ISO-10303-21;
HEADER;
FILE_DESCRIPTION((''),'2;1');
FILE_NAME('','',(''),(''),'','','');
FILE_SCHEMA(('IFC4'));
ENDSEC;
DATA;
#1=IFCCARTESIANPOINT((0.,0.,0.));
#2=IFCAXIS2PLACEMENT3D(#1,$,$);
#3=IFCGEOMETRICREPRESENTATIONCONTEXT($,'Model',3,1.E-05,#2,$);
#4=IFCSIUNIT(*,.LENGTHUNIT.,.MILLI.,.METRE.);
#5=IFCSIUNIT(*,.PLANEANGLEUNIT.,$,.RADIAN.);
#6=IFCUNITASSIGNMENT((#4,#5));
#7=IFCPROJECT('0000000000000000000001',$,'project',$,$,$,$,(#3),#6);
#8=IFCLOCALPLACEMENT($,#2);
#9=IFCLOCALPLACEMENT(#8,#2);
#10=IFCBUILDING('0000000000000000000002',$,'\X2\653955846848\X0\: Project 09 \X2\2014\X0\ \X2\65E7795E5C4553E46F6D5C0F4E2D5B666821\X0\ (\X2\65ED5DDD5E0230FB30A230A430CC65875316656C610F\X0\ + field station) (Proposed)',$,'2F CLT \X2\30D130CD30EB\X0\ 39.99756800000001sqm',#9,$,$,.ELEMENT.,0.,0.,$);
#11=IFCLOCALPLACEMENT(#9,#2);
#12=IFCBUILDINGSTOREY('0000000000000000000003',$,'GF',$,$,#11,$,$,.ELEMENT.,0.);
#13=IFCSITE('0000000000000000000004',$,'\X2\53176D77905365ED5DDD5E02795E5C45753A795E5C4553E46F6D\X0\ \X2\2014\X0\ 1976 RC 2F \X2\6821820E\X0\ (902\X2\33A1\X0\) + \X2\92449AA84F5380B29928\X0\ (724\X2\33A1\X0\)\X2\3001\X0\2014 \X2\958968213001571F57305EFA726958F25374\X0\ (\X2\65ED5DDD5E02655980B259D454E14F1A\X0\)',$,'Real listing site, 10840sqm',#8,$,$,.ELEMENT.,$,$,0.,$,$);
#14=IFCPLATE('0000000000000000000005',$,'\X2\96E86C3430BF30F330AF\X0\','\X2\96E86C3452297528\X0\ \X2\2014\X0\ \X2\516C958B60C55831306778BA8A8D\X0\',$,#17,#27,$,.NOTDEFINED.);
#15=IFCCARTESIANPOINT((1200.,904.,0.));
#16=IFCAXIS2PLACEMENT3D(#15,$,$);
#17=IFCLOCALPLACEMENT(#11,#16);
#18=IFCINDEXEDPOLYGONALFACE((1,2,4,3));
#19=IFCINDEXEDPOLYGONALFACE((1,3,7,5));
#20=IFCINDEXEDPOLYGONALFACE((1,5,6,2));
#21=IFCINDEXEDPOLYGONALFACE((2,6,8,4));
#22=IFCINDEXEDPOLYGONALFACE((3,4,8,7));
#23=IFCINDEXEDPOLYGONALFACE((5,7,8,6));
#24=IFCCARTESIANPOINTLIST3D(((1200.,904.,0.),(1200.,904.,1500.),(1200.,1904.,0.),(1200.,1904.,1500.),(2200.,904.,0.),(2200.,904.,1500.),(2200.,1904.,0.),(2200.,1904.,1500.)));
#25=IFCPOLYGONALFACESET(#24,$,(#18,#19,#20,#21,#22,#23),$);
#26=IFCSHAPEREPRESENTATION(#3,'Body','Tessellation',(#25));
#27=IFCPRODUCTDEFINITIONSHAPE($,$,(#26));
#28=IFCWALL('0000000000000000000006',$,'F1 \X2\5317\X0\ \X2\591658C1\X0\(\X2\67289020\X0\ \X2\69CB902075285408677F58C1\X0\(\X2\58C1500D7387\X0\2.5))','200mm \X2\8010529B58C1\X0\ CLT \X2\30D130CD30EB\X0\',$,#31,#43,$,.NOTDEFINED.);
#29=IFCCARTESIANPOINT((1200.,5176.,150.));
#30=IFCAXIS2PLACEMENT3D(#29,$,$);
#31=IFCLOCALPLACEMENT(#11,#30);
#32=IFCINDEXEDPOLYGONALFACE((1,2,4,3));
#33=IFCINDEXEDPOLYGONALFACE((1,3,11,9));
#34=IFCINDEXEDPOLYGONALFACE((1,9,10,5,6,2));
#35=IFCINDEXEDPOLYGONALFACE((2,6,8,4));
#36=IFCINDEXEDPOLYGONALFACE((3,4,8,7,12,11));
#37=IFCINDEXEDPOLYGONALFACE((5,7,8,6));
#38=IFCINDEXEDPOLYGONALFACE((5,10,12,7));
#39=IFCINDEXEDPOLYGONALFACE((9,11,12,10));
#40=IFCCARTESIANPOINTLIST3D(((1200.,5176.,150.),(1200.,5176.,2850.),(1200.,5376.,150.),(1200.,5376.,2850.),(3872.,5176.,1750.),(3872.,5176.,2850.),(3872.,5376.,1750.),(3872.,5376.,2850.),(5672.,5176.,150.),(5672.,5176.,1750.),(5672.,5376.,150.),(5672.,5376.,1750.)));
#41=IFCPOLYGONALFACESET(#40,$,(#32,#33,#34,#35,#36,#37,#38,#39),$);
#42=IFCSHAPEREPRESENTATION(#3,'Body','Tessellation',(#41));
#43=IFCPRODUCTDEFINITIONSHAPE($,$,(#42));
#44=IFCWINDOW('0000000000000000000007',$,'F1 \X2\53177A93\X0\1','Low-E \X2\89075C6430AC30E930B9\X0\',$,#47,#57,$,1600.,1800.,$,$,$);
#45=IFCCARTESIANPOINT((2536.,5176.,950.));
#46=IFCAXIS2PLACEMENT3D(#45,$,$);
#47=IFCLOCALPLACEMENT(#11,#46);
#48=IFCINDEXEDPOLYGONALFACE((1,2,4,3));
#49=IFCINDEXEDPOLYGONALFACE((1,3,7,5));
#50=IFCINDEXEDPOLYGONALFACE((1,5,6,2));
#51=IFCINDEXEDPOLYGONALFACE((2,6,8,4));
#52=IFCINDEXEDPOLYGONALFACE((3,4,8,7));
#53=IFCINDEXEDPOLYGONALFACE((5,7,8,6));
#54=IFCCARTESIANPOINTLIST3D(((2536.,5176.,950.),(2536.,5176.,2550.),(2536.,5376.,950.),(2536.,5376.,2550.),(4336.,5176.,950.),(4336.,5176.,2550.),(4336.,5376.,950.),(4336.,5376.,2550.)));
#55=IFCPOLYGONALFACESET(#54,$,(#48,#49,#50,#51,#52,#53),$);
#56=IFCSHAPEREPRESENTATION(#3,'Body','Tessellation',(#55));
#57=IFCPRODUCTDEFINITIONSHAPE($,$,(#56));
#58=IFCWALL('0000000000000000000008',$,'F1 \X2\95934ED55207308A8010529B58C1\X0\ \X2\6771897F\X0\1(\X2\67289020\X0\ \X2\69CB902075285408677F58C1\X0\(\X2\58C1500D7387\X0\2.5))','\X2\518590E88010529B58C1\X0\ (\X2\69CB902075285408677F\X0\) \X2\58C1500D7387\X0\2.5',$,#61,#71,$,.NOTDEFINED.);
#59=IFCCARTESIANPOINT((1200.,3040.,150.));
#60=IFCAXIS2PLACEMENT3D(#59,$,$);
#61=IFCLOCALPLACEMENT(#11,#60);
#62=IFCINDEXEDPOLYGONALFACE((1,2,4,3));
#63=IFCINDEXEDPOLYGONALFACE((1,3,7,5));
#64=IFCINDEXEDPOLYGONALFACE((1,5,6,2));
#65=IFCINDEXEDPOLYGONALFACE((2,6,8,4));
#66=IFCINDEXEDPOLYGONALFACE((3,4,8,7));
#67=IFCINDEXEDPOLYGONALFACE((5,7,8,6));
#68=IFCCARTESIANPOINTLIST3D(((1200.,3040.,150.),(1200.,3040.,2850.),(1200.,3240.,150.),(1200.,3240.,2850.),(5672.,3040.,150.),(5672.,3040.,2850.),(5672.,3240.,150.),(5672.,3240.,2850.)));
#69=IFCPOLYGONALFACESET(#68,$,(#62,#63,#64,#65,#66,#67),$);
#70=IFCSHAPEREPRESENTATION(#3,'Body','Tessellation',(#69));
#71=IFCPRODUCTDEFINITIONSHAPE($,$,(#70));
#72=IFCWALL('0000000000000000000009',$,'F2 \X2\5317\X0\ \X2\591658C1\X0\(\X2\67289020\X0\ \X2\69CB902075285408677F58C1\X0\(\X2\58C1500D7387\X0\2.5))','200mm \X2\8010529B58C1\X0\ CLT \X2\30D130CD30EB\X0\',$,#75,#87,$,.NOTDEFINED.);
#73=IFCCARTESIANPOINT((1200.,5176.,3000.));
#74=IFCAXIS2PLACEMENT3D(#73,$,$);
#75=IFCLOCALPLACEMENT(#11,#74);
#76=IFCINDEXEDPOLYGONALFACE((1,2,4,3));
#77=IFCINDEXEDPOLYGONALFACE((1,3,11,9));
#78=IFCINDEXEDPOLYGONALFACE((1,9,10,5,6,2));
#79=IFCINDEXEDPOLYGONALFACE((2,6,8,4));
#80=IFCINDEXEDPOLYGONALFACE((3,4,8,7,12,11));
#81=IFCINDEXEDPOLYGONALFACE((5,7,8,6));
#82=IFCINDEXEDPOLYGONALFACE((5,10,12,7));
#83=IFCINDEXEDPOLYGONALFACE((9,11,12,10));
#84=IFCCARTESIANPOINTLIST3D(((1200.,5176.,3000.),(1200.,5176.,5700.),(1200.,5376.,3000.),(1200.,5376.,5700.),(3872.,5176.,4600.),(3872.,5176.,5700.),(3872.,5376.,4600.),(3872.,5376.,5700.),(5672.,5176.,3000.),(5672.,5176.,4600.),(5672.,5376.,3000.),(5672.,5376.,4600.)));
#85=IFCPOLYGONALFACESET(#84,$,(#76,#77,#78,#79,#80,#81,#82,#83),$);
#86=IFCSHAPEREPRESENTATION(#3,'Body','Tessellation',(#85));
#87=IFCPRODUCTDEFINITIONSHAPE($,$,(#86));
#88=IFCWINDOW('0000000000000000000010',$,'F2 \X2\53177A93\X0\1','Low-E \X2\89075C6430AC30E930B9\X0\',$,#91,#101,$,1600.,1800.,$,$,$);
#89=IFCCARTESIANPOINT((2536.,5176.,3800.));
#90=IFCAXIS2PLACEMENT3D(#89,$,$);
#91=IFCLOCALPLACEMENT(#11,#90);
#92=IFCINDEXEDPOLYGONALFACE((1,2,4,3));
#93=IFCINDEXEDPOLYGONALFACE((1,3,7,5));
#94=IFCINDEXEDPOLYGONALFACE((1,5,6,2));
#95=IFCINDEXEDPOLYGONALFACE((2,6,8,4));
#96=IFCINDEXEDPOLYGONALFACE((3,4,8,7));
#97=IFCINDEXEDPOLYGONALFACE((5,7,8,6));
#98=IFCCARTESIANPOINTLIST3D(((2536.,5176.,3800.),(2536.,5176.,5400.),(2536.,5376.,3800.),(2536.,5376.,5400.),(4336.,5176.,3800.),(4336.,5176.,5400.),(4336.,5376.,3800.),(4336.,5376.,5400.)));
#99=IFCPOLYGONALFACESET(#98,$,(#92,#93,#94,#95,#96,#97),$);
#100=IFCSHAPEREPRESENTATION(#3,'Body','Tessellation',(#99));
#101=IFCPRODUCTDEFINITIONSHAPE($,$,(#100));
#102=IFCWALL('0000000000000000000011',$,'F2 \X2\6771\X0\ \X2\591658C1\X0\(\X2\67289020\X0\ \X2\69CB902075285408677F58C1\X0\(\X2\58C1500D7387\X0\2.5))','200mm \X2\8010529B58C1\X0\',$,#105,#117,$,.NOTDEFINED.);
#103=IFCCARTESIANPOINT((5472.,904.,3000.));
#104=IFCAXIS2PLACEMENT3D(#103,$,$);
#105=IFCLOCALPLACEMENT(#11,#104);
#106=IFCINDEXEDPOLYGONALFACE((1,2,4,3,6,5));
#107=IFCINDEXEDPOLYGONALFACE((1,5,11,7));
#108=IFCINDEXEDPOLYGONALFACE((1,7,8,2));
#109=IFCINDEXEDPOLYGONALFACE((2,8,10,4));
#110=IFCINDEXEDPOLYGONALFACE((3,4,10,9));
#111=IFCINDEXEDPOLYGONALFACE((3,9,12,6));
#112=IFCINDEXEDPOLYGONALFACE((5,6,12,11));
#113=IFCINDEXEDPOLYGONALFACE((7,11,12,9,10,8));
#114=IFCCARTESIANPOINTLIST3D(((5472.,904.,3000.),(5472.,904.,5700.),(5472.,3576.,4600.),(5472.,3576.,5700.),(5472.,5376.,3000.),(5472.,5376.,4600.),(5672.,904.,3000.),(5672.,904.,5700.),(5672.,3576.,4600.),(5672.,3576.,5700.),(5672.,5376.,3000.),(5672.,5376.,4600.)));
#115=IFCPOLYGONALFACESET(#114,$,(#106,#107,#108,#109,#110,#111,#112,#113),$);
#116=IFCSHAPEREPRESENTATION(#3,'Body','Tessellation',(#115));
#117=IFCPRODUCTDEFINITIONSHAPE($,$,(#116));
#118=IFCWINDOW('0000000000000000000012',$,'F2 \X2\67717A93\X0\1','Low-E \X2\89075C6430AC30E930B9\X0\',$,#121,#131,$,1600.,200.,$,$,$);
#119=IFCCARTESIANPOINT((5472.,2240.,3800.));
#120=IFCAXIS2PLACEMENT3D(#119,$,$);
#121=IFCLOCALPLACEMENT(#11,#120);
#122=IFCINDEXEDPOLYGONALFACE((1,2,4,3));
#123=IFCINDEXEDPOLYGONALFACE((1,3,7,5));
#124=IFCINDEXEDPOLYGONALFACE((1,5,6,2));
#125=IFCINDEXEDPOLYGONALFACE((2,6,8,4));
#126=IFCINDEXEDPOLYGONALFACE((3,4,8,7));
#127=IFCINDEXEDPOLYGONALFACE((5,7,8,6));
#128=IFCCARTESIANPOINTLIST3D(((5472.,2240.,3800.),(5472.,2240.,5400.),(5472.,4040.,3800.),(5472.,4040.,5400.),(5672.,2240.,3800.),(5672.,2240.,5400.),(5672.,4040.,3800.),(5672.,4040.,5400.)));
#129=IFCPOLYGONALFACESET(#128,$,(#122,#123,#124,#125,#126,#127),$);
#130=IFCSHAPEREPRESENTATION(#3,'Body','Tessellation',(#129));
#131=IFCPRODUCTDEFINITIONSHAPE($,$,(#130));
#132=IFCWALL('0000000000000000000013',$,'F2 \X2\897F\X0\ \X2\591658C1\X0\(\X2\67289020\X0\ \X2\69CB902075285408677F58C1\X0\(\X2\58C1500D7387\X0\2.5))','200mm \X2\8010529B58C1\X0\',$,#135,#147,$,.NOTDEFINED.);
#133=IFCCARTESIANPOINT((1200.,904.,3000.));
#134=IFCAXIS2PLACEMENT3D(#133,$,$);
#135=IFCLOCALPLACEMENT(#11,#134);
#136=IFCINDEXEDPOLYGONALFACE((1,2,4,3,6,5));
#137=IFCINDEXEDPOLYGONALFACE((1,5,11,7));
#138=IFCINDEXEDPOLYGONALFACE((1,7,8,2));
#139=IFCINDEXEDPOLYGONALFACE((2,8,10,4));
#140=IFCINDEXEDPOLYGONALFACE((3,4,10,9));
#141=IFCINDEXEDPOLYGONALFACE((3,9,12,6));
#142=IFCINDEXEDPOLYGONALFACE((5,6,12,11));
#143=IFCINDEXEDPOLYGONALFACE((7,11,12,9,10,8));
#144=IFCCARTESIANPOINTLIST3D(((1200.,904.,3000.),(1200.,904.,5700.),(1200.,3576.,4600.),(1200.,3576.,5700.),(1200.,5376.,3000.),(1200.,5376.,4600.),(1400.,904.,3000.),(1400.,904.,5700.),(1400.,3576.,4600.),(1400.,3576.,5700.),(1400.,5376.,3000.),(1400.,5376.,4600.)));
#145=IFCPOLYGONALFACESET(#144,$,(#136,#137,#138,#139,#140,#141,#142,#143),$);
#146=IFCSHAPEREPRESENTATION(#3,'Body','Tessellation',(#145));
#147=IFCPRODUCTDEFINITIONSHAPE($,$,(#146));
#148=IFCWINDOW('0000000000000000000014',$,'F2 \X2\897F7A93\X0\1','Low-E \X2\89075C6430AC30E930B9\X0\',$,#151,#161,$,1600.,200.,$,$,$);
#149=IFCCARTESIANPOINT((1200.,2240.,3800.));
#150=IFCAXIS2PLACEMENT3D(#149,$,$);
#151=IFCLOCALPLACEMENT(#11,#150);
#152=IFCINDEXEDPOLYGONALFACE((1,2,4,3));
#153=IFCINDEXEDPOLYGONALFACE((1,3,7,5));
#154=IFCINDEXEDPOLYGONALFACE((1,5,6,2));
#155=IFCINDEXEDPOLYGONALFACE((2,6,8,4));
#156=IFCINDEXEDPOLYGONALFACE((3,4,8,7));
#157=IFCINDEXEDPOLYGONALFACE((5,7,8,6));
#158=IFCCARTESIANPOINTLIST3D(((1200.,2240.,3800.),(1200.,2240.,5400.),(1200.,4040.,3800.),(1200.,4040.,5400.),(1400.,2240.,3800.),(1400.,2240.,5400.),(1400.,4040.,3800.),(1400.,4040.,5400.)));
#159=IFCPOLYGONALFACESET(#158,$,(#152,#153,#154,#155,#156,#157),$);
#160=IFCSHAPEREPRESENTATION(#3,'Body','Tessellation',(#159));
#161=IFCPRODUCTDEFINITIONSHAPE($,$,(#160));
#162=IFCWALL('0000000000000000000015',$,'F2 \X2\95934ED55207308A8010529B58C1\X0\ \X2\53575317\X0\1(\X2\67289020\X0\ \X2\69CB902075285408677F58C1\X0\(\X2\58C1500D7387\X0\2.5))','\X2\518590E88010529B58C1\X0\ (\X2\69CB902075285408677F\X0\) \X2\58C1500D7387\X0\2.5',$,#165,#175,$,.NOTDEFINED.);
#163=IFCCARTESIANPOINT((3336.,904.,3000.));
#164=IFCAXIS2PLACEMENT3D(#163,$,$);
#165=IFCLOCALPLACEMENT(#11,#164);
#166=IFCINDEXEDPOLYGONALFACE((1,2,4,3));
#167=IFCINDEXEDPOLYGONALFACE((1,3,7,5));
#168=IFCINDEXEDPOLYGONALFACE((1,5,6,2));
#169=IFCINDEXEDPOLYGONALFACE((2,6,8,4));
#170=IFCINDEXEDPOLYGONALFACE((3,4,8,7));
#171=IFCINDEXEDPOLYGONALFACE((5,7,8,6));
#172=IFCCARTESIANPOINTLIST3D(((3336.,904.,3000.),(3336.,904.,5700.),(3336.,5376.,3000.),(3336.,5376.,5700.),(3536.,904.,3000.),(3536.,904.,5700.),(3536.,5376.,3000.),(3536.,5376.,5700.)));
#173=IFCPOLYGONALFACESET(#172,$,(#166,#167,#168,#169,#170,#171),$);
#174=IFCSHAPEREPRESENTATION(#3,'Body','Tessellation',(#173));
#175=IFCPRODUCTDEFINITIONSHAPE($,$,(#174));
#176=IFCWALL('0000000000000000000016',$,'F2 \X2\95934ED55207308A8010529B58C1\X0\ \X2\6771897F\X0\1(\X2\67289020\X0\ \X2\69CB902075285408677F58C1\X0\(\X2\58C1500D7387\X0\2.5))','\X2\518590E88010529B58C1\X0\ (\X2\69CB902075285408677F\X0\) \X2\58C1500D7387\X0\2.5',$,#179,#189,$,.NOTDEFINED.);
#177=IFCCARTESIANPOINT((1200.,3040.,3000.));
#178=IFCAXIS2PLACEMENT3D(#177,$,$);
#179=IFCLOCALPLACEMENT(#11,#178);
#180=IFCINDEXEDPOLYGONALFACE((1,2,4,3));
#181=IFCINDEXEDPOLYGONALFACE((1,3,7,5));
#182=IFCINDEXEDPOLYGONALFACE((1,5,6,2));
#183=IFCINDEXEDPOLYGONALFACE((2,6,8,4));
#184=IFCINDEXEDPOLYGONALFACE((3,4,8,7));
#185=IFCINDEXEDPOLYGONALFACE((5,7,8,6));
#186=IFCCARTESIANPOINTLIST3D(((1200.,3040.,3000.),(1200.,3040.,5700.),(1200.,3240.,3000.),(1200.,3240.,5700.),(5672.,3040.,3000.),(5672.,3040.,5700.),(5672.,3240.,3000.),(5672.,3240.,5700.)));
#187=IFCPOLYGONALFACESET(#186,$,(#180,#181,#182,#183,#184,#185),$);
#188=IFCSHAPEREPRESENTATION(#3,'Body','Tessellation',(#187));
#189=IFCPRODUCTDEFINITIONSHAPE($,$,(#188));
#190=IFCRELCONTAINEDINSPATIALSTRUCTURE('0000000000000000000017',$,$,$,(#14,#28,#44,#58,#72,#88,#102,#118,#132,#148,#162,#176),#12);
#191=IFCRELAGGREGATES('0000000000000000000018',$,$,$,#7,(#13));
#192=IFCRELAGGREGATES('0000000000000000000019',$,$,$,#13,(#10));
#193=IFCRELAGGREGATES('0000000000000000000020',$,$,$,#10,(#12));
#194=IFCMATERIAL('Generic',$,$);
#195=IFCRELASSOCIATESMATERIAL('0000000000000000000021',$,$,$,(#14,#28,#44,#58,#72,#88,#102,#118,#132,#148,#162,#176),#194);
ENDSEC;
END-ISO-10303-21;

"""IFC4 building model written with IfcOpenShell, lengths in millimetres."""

from ifc_helpers import new_model, si_unit, frame, frame_2d, origin, place, context, project, spatial, rectangle, extrude, material, element, fill, save


model = new_model("IFC4")

# Units and contexts
model_context = context("Model", 3, precision=1e-05, world=origin())
ifc_project = project(units=[si_unit("LENGTHUNIT", "METRE", prefix="MILLI"), si_unit("PLANEANGLEUNIT", "RADIAN")], contexts=[model_context])

# Site, building, storey
site_placement = place(None, origin())
site = spatial("IfcSite", under=ifc_project, at=site_placement, Name="北海道旭川市神居町神居古潭 — 1976 RC 2F 校舎 (902㎡) + 鉄骨体育館 (724㎡)、2014 閉校、土地建物売却 (旭川市教育委員会)", ObjectType="Real listing site, 10840sqm", CompositionType="ELEMENT", RefElevation=0.0)
building_placement = place(site_placement, origin())
building = spatial("IfcBuilding", under=site, at=building_placement, Name="改善案: Project 09 — 旧神居古潭小中学校 (旭川市・アイヌ文化敬意 + field station) (Proposed)", ObjectType="2F CLT パネル 39.99756800000001sqm", CompositionType="ELEMENT", ElevationOfRefHeight=0.0, ElevationOfTerrain=0.0)
storey_placement = place(building_placement, origin())
storey = spatial("IfcBuildingStorey", under=building, at=storey_placement, Name="GF", CompositionType="ELEMENT", Elevation=0.0)

# Plate
ifc_material_1 = material(Name="Generic")
plate_placement = place(storey_placement, frame((1200.0, 904.0, 0.0)))
element("IfcPlate", 1, at=plate_placement, inside=storey, material=ifc_material_1, Name="雨水タンク", Description="雨水利用 — 公開情報で確認", PredefinedType="NOTDEFINED", context=model_context, shape_type="SweptSolid", body=[
    extrude(rectangle(XDim=1000.0, YDim=1000.0, at=frame_2d((500.0, 500.0))), frame((1200.0, 904.0, 0.0)), (0.0, 0.0, 1.0), 1500.0),
])

# Wall, opening, window
wall_1_placement = place(storey_placement, frame((1200.0, 5176.0, 150.0)))
wall_1 = element("IfcWall", 2, at=wall_1_placement, inside=storey, material=ifc_material_1, Name="F1 北 外壁(木造 構造用合板壁(壁倍率2.5))", Description="200mm 耐力壁 CLT パネル", PredefinedType="NOTDEFINED", context=model_context, shape_type="SweptSolid", body=[
    extrude(rectangle(XDim=4472.0, YDim=200.0, at=frame_2d((2236.0, 100.0))), frame((1200.0, 5176.0, 150.0)), (0.0, 0.0, 1.0), 2700.0),
])
opening_1_placement = place(storey_placement, frame((2536.0, 5176.0, 950.0)))
opening_1 = element("IfcOpeningElement", 3, at=opening_1_placement, cuts=wall_1, PredefinedType="NOTDEFINED", context=model_context, shape_type="SweptSolid", body=[
    extrude(rectangle(XDim=1800.0, YDim=200.0, at=frame_2d((900.0, 100.0))), frame((2536.0, 5176.0, 950.0)), (0.0, 0.0, 1.0), 1600.0),
])
window_1_placement = place(storey_placement, frame((2536.0, 5176.0, 950.0)))
window_1 = element("IfcWindow", 4, at=window_1_placement, inside=storey, material=ifc_material_1, Name="F1 北窓1", Description="Low-E 複層ガラス", OverallHeight=1600.0, OverallWidth=1800.0, context=model_context, shape_type="SweptSolid", body=[
    extrude(rectangle(XDim=1800.0, YDim=200.0, at=frame_2d((900.0, 100.0))), frame((2536.0, 5176.0, 950.0)), (0.0, 0.0, 1.0), 1600.0),
])
fill(opening_1, window_1)

# Wall
wall_2_placement = place(storey_placement, frame((1200.0, 3040.0, 150.0)))
element("IfcWall", 5, at=wall_2_placement, inside=storey, material=ifc_material_1, Name="F1 間仕切り耐力壁 東西1(木造 構造用合板壁(壁倍率2.5))", Description="内部耐力壁 (構造用合板) 壁倍率2.5", PredefinedType="NOTDEFINED", context=model_context, shape_type="SweptSolid", body=[
    extrude(rectangle(XDim=4472.0, YDim=200.0, at=frame_2d((2236.0, 100.0))), frame((1200.0, 3040.0, 150.0)), (0.0, 0.0, 1.0), 2700.0),
])

# Walls, openings, windows
wall_3_placement = place(storey_placement, frame((1200.0, 5176.0, 3000.0)))
wall_3 = element("IfcWall", 6, at=wall_3_placement, inside=storey, material=ifc_material_1, Name="F2 北 外壁(木造 構造用合板壁(壁倍率2.5))", Description="200mm 耐力壁 CLT パネル", PredefinedType="NOTDEFINED", context=model_context, shape_type="SweptSolid", body=[
    extrude(rectangle(XDim=4472.0, YDim=200.0, at=frame_2d((2236.0, 100.0))), frame((1200.0, 5176.0, 3000.0)), (0.0, 0.0, 1.0), 2700.0),
])
opening_2_placement = place(storey_placement, frame((2536.0, 5176.0, 3800.0)))
opening_2 = element("IfcOpeningElement", 7, at=opening_2_placement, cuts=wall_3, PredefinedType="NOTDEFINED", context=model_context, shape_type="SweptSolid", body=[
    extrude(rectangle(XDim=1800.0, YDim=200.0, at=frame_2d((900.0, 100.0))), frame((2536.0, 5176.0, 3800.0)), (0.0, 0.0, 1.0), 1600.0),
])
window_2_placement = place(storey_placement, frame((2536.0, 5176.0, 3800.0)))
window_2 = element("IfcWindow", 8, at=window_2_placement, inside=storey, material=ifc_material_1, Name="F2 北窓1", Description="Low-E 複層ガラス", OverallHeight=1600.0, OverallWidth=1800.0, context=model_context, shape_type="SweptSolid", body=[
    extrude(rectangle(XDim=1800.0, YDim=200.0, at=frame_2d((900.0, 100.0))), frame((2536.0, 5176.0, 3800.0)), (0.0, 0.0, 1.0), 1600.0),
])
fill(opening_2, window_2)
wall_4_placement = place(storey_placement, frame((5472.0, 904.0, 3000.0)))
wall_4 = element("IfcWall", 9, at=wall_4_placement, inside=storey, material=ifc_material_1, Name="F2 東 外壁(木造 構造用合板壁(壁倍率2.5))", Description="200mm 耐力壁", PredefinedType="NOTDEFINED", context=model_context, shape_type="SweptSolid", body=[
    extrude(rectangle(XDim=200.0, YDim=4472.0, at=frame_2d((100.0, 2236.0))), frame((5472.0, 904.0, 3000.0)), (0.0, 0.0, 1.0), 2700.0),
])
opening_3_placement = place(storey_placement, frame((5472.0, 2240.0, 3800.0)))
opening_3 = element("IfcOpeningElement", 10, at=opening_3_placement, cuts=wall_4, PredefinedType="NOTDEFINED", context=model_context, shape_type="SweptSolid", body=[
    extrude(rectangle(XDim=200.0, YDim=1800.0, at=frame_2d((100.0, 900.0))), frame((5472.0, 2240.0, 3800.0)), (0.0, 0.0, 1.0), 1600.0),
])
window_3_placement = place(storey_placement, frame((5472.0, 2240.0, 3800.0)))
window_3 = element("IfcWindow", 11, at=window_3_placement, inside=storey, material=ifc_material_1, Name="F2 東窓1", Description="Low-E 複層ガラス", OverallHeight=1600.0, OverallWidth=200.0, context=model_context, shape_type="SweptSolid", body=[
    extrude(rectangle(XDim=200.0, YDim=1800.0, at=frame_2d((100.0, 900.0))), frame((5472.0, 2240.0, 3800.0)), (0.0, 0.0, 1.0), 1600.0),
])
fill(opening_3, window_3)
wall_5_placement = place(storey_placement, frame((1200.0, 904.0, 3000.0)))
wall_5 = element("IfcWall", 12, at=wall_5_placement, inside=storey, material=ifc_material_1, Name="F2 西 外壁(木造 構造用合板壁(壁倍率2.5))", Description="200mm 耐力壁", PredefinedType="NOTDEFINED", context=model_context, shape_type="SweptSolid", body=[
    extrude(rectangle(XDim=200.0, YDim=4472.0, at=frame_2d((100.0, 2236.0))), frame((1200.0, 904.0, 3000.0)), (0.0, 0.0, 1.0), 2700.0),
])
opening_4_placement = place(storey_placement, frame((1200.0, 2240.0, 3800.0)))
opening_4 = element("IfcOpeningElement", 13, at=opening_4_placement, cuts=wall_5, PredefinedType="NOTDEFINED", context=model_context, shape_type="SweptSolid", body=[
    extrude(rectangle(XDim=200.0, YDim=1800.0, at=frame_2d((100.0, 900.0))), frame((1200.0, 2240.0, 3800.0)), (0.0, 0.0, 1.0), 1600.0),
])
window_4_placement = place(storey_placement, frame((1200.0, 2240.0, 3800.0)))
window_4 = element("IfcWindow", 14, at=window_4_placement, inside=storey, material=ifc_material_1, Name="F2 西窓1", Description="Low-E 複層ガラス", OverallHeight=1600.0, OverallWidth=200.0, context=model_context, shape_type="SweptSolid", body=[
    extrude(rectangle(XDim=200.0, YDim=1800.0, at=frame_2d((100.0, 900.0))), frame((1200.0, 2240.0, 3800.0)), (0.0, 0.0, 1.0), 1600.0),
])
fill(opening_4, window_4)

# Walls
wall_6_placement = place(storey_placement, frame((3336.0, 904.0, 3000.0)))
element("IfcWall", 15, at=wall_6_placement, inside=storey, material=ifc_material_1, Name="F2 間仕切り耐力壁 南北1(木造 構造用合板壁(壁倍率2.5))", Description="内部耐力壁 (構造用合板) 壁倍率2.5", PredefinedType="NOTDEFINED", context=model_context, shape_type="SweptSolid", body=[
    extrude(rectangle(XDim=200.0, YDim=4472.0, at=frame_2d((100.0, 2236.0))), frame((3336.0, 904.0, 3000.0)), (0.0, 0.0, 1.0), 2700.0),
])
wall_7_placement = place(storey_placement, frame((1200.0, 3040.0, 3000.0)))
element("IfcWall", 16, at=wall_7_placement, inside=storey, material=ifc_material_1, Name="F2 間仕切り耐力壁 東西1(木造 構造用合板壁(壁倍率2.5))", Description="内部耐力壁 (構造用合板) 壁倍率2.5", PredefinedType="NOTDEFINED", context=model_context, shape_type="SweptSolid", body=[
    extrude(rectangle(XDim=4472.0, YDim=200.0, at=frame_2d((2236.0, 100.0))), frame((1200.0, 3040.0, 3000.0)), (0.0, 0.0, 1.0), 2700.0),
])

save(model, "model.ifc")
